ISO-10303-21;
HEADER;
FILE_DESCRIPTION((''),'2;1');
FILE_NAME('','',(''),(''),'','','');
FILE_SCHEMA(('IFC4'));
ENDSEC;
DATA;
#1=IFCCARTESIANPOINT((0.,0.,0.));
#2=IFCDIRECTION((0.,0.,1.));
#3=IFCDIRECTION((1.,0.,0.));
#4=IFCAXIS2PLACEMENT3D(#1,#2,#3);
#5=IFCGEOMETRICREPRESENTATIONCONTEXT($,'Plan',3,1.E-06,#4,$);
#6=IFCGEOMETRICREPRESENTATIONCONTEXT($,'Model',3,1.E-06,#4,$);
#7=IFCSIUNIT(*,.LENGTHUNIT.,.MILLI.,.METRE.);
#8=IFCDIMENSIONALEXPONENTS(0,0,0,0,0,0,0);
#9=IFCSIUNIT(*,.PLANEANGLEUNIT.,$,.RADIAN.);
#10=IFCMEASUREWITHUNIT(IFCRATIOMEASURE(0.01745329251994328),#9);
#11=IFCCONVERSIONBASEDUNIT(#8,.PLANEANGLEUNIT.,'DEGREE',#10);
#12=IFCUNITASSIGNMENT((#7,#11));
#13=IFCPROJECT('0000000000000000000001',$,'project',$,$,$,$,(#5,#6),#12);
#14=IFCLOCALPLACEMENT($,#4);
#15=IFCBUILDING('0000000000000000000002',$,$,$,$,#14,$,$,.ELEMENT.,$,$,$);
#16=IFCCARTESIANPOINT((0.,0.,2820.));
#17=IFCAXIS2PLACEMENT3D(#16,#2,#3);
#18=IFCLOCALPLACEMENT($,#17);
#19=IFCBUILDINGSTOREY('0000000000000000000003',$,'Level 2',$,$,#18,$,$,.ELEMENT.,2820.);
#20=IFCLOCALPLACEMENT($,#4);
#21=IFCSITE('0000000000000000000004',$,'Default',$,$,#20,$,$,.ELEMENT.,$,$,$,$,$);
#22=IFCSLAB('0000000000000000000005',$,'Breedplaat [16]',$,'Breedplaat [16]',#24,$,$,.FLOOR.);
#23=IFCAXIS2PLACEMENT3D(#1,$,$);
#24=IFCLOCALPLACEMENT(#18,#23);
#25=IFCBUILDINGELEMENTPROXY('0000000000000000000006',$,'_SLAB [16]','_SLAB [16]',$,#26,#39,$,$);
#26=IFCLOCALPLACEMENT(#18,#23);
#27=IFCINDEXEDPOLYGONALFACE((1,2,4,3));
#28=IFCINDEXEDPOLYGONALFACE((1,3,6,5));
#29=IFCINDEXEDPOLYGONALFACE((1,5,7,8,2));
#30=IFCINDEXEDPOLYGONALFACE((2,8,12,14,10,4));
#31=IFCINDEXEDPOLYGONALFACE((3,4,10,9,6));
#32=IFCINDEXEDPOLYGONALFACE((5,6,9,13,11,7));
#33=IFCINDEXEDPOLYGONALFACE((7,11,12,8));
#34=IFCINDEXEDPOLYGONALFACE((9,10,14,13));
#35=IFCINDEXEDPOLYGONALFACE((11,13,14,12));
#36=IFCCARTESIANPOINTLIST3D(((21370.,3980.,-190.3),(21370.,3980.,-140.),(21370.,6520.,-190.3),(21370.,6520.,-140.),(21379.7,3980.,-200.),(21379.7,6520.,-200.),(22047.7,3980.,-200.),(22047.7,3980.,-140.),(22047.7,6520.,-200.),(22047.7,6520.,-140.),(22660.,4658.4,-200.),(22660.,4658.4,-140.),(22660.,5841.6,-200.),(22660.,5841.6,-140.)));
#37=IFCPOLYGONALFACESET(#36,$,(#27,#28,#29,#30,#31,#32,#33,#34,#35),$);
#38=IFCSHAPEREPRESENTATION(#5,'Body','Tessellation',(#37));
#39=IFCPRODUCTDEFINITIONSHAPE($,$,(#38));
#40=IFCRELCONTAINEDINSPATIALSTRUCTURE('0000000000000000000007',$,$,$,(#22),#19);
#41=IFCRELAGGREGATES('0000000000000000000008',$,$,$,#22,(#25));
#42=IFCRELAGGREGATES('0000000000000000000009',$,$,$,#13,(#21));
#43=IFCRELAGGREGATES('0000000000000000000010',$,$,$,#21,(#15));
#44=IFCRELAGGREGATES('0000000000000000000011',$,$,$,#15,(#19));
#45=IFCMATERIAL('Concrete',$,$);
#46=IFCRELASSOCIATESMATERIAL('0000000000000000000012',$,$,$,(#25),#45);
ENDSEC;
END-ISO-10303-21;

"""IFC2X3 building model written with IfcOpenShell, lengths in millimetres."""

from ifc_helpers import new_model, entity, si_unit, converted_unit, frame, origin_with_axes, place, context, project, spatial, polyline, outline, extrude, material, element, aggregate, save


model = new_model("IFC2X3")

# Units and contexts
plan_context = context("Plan", 3, precision=1e-06, world=origin_with_axes())
model_context = context("Model", 3, precision=1e-06, world=origin_with_axes())
ifc_project = project(units=[si_unit("LENGTHUNIT", "METRE", prefix="MILLI"), converted_unit("PLANEANGLEUNIT", "DEGREE", entity("IfcRatioMeasure", 0.01745329251994328), si_unit("PLANEANGLEUNIT", "RADIAN"), dimensions=[0, 0, 0, 0, 0, 0, 0])], contexts=[plan_context, model_context])

# Site, building, storey
site_placement = place(None, origin_with_axes())
site = spatial("IfcSite", under=ifc_project, at=site_placement, Name="Default", CompositionType="ELEMENT")
building_placement = place(None, origin_with_axes())
building = spatial("IfcBuilding", under=site, at=building_placement, CompositionType="ELEMENT")
storey_placement = place(None, frame((0.0, 0.0, 2820.0), z_axis=(0.0, 0.0, 1.0), x_axis=(1.0, 0.0, 0.0)))
storey = spatial("IfcBuildingStorey", under=building, at=storey_placement, Name="Level 2", CompositionType="ELEMENT", Elevation=2820.0)

# Slab, building element proxy, opening
slab_1_placement = place(None, frame((21370.0, 6520.0, 2620.0), z_axis=(0.0, 0.0, 1.0), x_axis=(0.0, -1.0, 0.0)))
slab_1 = element("IfcSlab", 1, at=slab_1_placement, inside=storey, Name="Breedplaat [16]", ObjectType="Breedplaat [16]", PredefinedType="FLOOR")
ifc_material = material(Name="Concrete")
proxy_1_placement = place(slab_1_placement, origin_with_axes())
proxy_1 = element("IfcBuildingElementProxy", 2, at=proxy_1_placement, material=ifc_material, Name="_SLAB [16]", Description="_SLAB [16]", context=plan_context, shape_type="SweptSolid", body=[
    extrude(outline(polyline([(1861.6, 1290.0), (678.4, 1290.0), (0.0, 677.8), (0.0, 0.0), (2540.0, 0.0), (2540.0, 677.8), (1861.6, 1290.0)])), origin_with_axes(), (0.0, 0.0, 1.0), 60.0),
])
opening_placement = place(None, frame((21370.0, 6520.0, 2620.0), z_axis=(0.0, 0.0, 1.0), x_axis=(0.0, -1.0, 0.0)))
element("IfcOpeningElement", 3, at=opening_placement, cuts=proxy_1, ObjectType="Opening", context=plan_context, shape_type="SweptSolid", body=[
    extrude(outline(polyline([(-0.1, -0.1), (-0.1, 10.0), (10.0, -0.1), (-0.1, -0.1)])), frame((-1.2, -0.1, -0.1), z_axis=(1.0, 0.0, 0.0), x_axis=(0.0, 1.0, 0.0)), (0.0, 0.0, 1.0), 2542.2),
])
aggregate(slab_1, [proxy_1])

save(model, "model.ifc")
